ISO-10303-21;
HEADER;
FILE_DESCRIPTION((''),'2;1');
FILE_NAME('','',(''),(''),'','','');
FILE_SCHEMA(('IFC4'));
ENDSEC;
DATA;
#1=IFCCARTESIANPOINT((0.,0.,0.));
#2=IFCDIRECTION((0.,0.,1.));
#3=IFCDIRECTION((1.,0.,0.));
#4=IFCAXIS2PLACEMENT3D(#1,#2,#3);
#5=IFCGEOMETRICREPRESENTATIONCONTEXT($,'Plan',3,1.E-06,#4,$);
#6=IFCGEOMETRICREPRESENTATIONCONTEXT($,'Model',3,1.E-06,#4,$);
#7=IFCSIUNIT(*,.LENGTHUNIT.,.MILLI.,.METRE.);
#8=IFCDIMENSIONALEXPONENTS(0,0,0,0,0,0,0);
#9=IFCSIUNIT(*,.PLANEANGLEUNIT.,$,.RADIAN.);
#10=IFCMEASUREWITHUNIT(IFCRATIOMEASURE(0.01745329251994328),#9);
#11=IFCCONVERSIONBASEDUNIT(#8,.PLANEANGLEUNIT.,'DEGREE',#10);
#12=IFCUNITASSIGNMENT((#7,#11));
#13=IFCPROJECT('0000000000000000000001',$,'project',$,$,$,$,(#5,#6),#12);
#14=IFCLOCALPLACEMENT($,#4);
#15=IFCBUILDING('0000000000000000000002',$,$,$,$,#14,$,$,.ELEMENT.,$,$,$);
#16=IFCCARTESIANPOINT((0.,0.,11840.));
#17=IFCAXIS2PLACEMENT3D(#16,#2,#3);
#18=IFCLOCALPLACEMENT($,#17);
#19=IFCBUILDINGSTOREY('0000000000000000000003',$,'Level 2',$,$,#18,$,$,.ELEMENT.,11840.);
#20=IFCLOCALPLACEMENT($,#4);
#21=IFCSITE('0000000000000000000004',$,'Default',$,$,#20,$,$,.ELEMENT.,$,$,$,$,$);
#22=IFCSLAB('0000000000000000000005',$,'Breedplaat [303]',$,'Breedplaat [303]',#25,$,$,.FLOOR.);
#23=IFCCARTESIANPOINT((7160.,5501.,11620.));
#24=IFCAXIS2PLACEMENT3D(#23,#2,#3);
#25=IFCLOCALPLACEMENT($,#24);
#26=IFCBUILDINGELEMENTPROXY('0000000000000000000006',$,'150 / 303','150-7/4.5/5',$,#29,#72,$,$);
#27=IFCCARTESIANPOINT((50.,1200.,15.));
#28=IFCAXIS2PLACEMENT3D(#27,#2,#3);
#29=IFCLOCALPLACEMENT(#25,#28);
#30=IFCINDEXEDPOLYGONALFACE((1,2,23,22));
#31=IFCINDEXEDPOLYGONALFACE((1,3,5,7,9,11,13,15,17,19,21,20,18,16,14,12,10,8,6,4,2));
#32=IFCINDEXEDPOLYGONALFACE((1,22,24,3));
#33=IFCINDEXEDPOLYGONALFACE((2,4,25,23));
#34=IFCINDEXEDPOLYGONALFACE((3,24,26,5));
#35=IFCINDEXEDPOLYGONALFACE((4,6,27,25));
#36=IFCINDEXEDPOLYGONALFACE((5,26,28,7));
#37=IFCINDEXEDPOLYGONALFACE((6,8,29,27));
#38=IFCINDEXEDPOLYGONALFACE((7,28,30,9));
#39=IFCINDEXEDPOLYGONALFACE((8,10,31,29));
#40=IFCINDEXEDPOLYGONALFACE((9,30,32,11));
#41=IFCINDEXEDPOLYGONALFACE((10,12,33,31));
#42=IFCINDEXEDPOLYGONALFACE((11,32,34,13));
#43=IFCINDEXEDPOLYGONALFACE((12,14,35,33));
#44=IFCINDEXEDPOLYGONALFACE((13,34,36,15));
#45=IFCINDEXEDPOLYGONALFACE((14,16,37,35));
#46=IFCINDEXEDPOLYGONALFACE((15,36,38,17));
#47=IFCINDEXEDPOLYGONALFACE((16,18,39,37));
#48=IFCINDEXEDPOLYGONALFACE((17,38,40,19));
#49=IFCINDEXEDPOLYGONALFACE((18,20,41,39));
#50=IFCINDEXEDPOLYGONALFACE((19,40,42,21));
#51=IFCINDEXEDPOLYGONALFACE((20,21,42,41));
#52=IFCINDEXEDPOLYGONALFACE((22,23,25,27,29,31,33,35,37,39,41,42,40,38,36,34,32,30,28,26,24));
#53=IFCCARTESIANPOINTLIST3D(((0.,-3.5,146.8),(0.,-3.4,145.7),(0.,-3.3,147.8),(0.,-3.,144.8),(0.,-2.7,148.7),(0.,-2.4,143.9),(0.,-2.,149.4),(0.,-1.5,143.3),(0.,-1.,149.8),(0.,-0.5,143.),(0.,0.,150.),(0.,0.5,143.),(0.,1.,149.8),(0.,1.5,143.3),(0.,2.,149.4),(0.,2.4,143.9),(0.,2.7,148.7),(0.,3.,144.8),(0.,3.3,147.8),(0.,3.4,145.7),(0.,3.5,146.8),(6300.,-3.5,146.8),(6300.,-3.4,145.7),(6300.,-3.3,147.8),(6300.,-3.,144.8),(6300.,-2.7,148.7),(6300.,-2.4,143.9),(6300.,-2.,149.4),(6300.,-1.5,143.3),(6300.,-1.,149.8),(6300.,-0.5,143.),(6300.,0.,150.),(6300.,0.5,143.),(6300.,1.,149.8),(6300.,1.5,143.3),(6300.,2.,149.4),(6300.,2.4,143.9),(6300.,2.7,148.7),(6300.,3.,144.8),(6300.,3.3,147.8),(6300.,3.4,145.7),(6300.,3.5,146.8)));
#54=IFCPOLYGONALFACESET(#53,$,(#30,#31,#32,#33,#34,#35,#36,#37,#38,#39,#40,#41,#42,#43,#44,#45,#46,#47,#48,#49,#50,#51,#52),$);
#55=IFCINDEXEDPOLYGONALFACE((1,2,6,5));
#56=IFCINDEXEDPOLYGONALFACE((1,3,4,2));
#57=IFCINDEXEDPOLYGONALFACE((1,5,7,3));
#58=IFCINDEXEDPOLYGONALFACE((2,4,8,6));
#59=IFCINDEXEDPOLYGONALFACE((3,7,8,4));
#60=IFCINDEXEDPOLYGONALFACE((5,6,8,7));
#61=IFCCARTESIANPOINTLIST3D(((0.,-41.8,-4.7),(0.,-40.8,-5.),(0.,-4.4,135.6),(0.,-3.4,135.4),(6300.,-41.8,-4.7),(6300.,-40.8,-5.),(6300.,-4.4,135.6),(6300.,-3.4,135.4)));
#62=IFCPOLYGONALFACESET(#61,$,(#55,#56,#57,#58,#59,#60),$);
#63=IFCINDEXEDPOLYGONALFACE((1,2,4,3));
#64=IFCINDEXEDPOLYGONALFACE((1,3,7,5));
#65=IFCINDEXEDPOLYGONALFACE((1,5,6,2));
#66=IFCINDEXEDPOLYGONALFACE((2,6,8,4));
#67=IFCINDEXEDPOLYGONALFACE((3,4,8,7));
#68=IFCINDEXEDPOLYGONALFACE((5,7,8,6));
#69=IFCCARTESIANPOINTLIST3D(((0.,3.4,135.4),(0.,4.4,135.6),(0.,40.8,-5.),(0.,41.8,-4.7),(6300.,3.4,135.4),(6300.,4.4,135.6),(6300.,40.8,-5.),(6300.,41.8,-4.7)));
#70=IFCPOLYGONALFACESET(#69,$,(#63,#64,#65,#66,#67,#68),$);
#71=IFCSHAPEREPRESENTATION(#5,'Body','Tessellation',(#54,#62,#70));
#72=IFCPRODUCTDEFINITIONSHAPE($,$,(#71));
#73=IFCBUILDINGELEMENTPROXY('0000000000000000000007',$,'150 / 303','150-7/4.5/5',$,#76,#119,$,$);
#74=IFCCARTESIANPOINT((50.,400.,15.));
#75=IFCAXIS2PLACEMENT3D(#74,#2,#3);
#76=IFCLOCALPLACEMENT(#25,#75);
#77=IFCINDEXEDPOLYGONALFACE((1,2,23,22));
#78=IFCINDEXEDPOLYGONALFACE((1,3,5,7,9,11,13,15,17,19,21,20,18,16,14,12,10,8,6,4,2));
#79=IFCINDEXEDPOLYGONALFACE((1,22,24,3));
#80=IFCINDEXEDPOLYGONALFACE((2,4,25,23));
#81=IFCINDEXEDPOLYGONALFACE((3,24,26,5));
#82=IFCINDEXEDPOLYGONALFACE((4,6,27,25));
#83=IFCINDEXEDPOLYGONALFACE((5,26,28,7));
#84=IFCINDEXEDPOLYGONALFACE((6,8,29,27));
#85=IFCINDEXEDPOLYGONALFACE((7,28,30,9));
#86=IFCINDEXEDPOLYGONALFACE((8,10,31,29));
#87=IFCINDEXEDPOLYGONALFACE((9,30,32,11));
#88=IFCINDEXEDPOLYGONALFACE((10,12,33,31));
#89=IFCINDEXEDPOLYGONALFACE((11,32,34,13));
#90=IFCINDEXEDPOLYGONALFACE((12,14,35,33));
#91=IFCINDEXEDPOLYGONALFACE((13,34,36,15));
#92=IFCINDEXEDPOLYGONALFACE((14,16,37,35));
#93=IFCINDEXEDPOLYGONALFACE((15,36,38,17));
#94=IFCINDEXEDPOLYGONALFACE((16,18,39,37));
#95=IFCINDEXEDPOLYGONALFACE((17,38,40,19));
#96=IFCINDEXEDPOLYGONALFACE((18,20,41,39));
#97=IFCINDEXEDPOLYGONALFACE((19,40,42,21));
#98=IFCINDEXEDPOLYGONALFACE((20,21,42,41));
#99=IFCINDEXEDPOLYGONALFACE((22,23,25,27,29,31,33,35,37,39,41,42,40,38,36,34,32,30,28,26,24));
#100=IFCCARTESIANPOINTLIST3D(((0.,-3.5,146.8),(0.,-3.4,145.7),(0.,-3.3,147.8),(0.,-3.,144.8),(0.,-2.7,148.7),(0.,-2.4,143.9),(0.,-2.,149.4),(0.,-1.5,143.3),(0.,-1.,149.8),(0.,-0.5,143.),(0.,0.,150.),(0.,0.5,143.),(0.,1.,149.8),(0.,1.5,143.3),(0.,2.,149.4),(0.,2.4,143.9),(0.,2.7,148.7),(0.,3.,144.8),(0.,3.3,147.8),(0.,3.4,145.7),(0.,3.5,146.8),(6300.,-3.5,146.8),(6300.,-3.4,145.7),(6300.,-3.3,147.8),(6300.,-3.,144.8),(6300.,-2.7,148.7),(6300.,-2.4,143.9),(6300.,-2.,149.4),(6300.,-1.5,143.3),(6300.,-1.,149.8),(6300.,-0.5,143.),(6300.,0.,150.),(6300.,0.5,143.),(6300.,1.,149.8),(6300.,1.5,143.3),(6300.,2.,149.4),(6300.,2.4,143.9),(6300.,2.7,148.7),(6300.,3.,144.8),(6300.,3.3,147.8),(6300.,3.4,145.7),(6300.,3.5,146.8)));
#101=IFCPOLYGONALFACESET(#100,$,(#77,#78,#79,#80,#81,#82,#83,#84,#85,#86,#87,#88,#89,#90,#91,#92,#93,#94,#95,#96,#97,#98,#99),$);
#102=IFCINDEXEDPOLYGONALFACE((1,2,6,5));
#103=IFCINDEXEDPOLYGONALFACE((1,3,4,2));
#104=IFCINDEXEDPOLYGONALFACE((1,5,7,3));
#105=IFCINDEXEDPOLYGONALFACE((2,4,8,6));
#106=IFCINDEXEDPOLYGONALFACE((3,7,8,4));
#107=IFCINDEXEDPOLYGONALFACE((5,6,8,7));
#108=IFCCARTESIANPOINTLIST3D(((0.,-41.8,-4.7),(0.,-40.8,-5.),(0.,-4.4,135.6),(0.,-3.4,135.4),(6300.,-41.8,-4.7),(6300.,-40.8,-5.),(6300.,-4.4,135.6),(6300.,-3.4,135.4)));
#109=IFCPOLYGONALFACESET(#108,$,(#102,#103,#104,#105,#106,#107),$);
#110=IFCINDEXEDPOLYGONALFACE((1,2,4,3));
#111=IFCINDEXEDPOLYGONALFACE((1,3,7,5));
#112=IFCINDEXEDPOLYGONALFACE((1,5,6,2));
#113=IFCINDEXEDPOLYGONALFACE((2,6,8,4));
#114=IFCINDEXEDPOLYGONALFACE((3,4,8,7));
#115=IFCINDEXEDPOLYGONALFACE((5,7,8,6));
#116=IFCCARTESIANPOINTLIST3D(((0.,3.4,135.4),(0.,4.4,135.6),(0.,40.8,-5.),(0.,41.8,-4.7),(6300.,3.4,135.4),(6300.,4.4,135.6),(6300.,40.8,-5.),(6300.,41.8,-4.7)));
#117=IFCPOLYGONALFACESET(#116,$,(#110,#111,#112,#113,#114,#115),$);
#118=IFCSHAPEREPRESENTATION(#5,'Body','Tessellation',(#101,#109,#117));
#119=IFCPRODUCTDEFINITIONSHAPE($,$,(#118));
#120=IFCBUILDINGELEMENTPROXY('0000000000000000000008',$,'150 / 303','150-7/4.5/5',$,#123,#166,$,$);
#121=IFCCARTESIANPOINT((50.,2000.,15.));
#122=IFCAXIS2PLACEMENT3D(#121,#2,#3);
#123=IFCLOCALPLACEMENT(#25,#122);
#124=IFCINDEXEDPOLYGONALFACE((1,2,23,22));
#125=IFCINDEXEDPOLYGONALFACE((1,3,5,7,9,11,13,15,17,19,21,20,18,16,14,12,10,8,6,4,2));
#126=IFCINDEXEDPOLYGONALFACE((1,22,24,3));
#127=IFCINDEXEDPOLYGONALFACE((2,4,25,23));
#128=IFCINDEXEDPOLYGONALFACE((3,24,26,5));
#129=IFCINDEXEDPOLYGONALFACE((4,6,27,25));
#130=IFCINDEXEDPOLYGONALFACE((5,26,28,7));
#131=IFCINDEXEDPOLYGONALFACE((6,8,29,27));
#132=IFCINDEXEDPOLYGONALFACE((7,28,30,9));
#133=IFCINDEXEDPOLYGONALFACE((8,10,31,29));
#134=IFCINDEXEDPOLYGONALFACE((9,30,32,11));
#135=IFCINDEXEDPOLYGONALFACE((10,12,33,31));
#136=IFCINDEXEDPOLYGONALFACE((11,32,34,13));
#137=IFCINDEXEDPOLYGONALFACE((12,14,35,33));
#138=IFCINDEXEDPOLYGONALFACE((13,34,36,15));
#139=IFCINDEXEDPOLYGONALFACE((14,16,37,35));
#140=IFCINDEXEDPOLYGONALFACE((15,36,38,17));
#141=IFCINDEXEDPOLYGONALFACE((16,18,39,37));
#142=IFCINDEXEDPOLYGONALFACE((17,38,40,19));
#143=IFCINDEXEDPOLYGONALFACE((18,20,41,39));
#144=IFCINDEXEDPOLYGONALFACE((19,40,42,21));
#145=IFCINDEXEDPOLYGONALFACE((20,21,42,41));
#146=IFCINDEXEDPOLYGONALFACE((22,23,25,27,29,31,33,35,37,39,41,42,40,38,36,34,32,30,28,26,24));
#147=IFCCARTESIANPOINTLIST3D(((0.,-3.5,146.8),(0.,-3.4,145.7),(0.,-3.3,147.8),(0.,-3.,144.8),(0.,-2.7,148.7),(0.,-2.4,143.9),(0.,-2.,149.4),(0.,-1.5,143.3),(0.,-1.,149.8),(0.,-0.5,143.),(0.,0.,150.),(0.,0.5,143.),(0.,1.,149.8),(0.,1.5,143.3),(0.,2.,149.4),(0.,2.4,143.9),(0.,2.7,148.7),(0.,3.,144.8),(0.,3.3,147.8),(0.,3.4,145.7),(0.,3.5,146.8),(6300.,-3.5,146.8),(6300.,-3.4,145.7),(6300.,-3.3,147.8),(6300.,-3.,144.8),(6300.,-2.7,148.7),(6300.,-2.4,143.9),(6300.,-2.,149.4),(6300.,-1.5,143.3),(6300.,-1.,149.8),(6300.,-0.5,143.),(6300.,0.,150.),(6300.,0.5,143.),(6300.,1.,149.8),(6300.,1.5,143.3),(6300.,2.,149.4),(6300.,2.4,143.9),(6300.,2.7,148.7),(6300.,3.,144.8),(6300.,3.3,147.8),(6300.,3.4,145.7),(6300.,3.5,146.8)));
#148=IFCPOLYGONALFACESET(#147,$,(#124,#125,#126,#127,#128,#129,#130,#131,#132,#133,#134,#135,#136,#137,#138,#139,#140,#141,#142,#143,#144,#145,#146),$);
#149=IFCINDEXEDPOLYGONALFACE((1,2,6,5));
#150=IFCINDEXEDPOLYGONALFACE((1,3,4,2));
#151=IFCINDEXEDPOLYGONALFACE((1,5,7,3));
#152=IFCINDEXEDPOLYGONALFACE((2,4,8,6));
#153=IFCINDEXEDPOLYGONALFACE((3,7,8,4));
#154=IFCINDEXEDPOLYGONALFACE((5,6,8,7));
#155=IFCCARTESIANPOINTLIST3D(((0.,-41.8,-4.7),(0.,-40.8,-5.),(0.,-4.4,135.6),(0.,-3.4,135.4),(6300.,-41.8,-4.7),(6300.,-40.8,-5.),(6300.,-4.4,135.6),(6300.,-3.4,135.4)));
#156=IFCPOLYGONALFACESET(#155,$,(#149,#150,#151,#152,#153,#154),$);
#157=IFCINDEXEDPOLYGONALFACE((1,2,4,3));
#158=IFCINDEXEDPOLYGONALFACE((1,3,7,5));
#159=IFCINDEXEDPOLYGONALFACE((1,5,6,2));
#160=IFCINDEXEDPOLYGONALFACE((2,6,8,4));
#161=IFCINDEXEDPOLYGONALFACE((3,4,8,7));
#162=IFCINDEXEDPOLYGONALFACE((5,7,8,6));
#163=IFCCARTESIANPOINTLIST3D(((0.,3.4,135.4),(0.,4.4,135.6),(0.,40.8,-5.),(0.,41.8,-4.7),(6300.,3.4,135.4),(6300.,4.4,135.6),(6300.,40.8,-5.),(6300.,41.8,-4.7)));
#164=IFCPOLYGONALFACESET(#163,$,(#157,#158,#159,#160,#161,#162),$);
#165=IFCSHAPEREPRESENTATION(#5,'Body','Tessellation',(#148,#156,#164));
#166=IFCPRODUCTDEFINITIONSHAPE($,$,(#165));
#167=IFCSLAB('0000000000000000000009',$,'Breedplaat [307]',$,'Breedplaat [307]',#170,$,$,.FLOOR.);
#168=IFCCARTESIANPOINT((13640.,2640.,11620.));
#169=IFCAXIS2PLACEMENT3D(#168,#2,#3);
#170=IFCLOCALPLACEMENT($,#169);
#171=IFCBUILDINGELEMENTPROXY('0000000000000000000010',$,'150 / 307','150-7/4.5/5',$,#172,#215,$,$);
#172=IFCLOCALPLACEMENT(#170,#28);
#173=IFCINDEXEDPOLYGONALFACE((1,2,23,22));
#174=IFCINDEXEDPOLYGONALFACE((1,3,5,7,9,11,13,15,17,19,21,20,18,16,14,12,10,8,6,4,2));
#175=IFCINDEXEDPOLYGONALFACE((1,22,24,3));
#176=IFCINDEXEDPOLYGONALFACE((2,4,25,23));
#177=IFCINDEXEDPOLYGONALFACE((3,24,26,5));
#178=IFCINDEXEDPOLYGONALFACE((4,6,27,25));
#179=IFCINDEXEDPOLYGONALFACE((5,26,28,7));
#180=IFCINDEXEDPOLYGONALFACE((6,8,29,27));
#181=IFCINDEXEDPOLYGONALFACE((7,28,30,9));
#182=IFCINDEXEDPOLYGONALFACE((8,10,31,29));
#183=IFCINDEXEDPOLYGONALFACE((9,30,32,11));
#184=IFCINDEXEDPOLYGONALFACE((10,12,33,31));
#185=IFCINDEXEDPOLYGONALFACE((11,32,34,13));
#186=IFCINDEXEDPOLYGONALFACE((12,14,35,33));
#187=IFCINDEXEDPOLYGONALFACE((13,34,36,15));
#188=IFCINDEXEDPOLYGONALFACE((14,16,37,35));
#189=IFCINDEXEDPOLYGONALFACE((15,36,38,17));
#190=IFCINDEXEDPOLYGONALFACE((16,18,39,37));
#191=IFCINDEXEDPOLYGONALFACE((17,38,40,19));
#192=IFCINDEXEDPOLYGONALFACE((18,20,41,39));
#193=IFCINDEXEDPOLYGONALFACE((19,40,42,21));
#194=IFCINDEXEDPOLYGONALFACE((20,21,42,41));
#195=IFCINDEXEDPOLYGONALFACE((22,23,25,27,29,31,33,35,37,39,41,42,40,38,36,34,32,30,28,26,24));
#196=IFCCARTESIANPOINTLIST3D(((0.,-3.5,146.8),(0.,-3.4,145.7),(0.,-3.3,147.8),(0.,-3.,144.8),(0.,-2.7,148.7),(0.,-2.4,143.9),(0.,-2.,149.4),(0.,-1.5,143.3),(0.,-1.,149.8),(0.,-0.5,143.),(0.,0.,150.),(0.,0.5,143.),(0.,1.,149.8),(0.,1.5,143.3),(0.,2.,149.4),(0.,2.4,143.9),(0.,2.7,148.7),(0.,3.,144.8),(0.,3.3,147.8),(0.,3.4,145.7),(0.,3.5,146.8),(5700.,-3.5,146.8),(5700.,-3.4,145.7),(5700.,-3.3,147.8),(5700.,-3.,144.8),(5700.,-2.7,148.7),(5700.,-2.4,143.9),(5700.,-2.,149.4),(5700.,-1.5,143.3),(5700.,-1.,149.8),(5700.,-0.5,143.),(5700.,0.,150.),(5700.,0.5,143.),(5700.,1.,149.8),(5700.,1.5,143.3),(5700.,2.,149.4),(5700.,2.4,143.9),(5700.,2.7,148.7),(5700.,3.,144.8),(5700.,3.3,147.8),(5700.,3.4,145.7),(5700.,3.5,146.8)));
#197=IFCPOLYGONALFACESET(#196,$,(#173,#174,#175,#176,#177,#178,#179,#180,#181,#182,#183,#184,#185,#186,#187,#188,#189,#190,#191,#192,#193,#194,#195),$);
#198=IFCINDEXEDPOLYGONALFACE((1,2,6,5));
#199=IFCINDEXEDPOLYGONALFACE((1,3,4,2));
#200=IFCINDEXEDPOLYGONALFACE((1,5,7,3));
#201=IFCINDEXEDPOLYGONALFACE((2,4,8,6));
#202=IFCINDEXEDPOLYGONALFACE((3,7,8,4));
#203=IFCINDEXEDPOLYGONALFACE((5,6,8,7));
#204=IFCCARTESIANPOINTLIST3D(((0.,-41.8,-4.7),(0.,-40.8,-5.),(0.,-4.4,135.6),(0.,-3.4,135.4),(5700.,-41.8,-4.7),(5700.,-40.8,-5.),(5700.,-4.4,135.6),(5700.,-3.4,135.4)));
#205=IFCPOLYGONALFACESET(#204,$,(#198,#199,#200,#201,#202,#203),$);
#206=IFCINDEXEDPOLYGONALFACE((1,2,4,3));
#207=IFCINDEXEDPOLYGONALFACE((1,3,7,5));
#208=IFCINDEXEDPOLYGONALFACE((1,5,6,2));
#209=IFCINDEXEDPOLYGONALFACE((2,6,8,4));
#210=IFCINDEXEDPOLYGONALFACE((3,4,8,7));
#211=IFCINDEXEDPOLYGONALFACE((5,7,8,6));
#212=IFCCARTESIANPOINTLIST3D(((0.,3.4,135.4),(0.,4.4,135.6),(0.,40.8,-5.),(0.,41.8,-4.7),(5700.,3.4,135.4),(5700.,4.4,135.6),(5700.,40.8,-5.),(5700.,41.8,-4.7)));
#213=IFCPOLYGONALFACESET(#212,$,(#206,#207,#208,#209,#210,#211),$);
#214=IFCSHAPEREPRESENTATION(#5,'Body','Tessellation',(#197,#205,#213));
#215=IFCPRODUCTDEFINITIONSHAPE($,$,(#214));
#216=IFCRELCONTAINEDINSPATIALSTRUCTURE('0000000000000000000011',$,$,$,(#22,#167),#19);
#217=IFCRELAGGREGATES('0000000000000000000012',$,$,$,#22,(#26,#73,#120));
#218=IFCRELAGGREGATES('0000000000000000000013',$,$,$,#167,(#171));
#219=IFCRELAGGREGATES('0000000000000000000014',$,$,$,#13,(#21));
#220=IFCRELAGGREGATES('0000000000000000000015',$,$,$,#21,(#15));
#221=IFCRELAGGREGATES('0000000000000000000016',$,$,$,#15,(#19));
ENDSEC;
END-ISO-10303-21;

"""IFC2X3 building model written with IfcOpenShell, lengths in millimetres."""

from ifc_helpers import new_model, entity, si_unit, converted_unit, frame, origin_with_axes, origin_2d_with_axis, place, context, project, spatial, rectangle, circle, extrude, element, aggregate, save


model = new_model("IFC2X3")

# Units and contexts
plan_context = context("Plan", 3, precision=1e-06, world=origin_with_axes())
model_context = context("Model", 3, precision=1e-06, world=origin_with_axes())
ifc_project = project(units=[si_unit("LENGTHUNIT", "METRE", prefix="MILLI"), converted_unit("PLANEANGLEUNIT", "DEGREE", entity("IfcRatioMeasure", 0.01745329251994328), si_unit("PLANEANGLEUNIT", "RADIAN"), dimensions=[0, 0, 0, 0, 0, 0, 0])], contexts=[plan_context, model_context])

# Site, building, storey
site_placement = place(None, origin_with_axes())
site = spatial("IfcSite", under=ifc_project, at=site_placement, Name="Default", CompositionType="ELEMENT")
building_placement = place(None, origin_with_axes())
building = spatial("IfcBuilding", under=site, at=building_placement, CompositionType="ELEMENT")
storey_placement = place(None, frame((0.0, 0.0, 11840.0), z_axis=(0.0, 0.0, 1.0), x_axis=(1.0, 0.0, 0.0)))
storey = spatial("IfcBuildingStorey", under=building, at=storey_placement, Name="Level 2", CompositionType="ELEMENT", Elevation=11840.0)

# Slab, building element proxies
slab_1_placement = place(None, frame((7160.0, 5501.0, 11620.0), z_axis=(0.0, 0.0, 1.0), x_axis=(1.0, 0.0, 0.0)))
slab_1 = element("IfcSlab", 1, at=slab_1_placement, inside=storey, Name="Breedplaat [303]", ObjectType="Breedplaat [303]", PredefinedType="FLOOR")
proxy_1_placement = place(slab_1_placement, frame((50.0, 1200.0, 15.0), z_axis=(0.0, 0.0, 1.0), x_axis=(1.0, 0.0, 0.0)))
proxy_1 = element("IfcBuildingElementProxy", 2, at=proxy_1_placement, Name="150 / 303", Description="150-7/4.5/5", context=plan_context, shape_type="SweptSolid", body=[
    extrude(circle(Radius=3.5, at=origin_2d_with_axis()), frame((0.0, 0.0, 146.5), z_axis=(1.0, 0.0, 0.0), x_axis=(0.0, 0.0, 1.0)), (0.0, 0.0, 1.0), 6300.0),
    extrude(rectangle(XDim=145.2, YDim=1.0, at=origin_2d_with_axis()), frame((0.0, -22.6, 65.3), z_axis=(1.0, 0.0, 0.0), x_axis=(0.0, 0.257663, 0.966235)), (0.0, 0.0, 1.0), 6300.0),
    extrude(rectangle(XDim=145.2, YDim=1.0, at=origin_2d_with_axis()), frame((0.0, 22.6, 65.3), z_axis=(1.0, 0.0, 0.0), x_axis=(0.0, -0.257663, 0.966235)), (0.0, 0.0, 1.0), 6300.0),
])
proxy_2_placement = place(slab_1_placement, frame((50.0, 400.0, 15.0), z_axis=(0.0, 0.0, 1.0), x_axis=(1.0, 0.0, 0.0)))
proxy_2 = element("IfcBuildingElementProxy", 3, at=proxy_2_placement, Name="150 / 303", Description="150-7/4.5/5", context=plan_context, shape_type="SweptSolid", body=[
    extrude(circle(Radius=3.5, at=origin_2d_with_axis()), frame((0.0, 0.0, 146.5), z_axis=(1.0, 0.0, 0.0), x_axis=(0.0, 0.0, 1.0)), (0.0, 0.0, 1.0), 6300.0),
    extrude(rectangle(XDim=145.2, YDim=1.0, at=origin_2d_with_axis()), frame((0.0, -22.6, 65.3), z_axis=(1.0, 0.0, 0.0), x_axis=(0.0, 0.257663, 0.966235)), (0.0, 0.0, 1.0), 6300.0),
    extrude(rectangle(XDim=145.2, YDim=1.0, at=origin_2d_with_axis()), frame((0.0, 22.6, 65.3), z_axis=(1.0, 0.0, 0.0), x_axis=(0.0, -0.257663, 0.966235)), (0.0, 0.0, 1.0), 6300.0),
])
proxy_3_placement = place(slab_1_placement, frame((50.0, 2000.0, 15.0), z_axis=(0.0, 0.0, 1.0), x_axis=(1.0, 0.0, 0.0)))
proxy_3 = element("IfcBuildingElementProxy", 4, at=proxy_3_placement, Name="150 / 303", Description="150-7/4.5/5", context=plan_context, shape_type="SweptSolid", body=[
    extrude(circle(Radius=3.5, at=origin_2d_with_axis()), frame((0.0, 0.0, 146.5), z_axis=(1.0, 0.0, 0.0), x_axis=(0.0, 0.0, 1.0)), (0.0, 0.0, 1.0), 6300.0),
    extrude(rectangle(XDim=145.2, YDim=1.0, at=origin_2d_with_axis()), frame((0.0, -22.6, 65.3), z_axis=(1.0, 0.0, 0.0), x_axis=(0.0, 0.257663, 0.966235)), (0.0, 0.0, 1.0), 6300.0),
    extrude(rectangle(XDim=145.2, YDim=1.0, at=origin_2d_with_axis()), frame((0.0, 22.6, 65.3), z_axis=(1.0, 0.0, 0.0), x_axis=(0.0, -0.257663, 0.966235)), (0.0, 0.0, 1.0), 6300.0),
])
aggregate(slab_1, [proxy_1, proxy_2, proxy_3])

# Slab, building element proxy
slab_2_placement = place(None, frame((13640.0, 2640.0, 11620.0), z_axis=(0.0, 0.0, 1.0), x_axis=(1.0, 0.0, 0.0)))
slab_2 = element("IfcSlab", 5, at=slab_2_placement, inside=storey, Name="Breedplaat [307]", ObjectType="Breedplaat [307]", PredefinedType="FLOOR")
proxy_4_placement = place(slab_2_placement, frame((50.0, 1200.0, 15.0), z_axis=(0.0, 0.0, 1.0), x_axis=(1.0, 0.0, 0.0)))
proxy_4 = element("IfcBuildingElementProxy", 6, at=proxy_4_placement, Name="150 / 307", Description="150-7/4.5/5", context=plan_context, shape_type="SweptSolid", body=[
    extrude(circle(Radius=3.5, at=origin_2d_with_axis()), frame((0.0, 0.0, 146.5), z_axis=(1.0, 0.0, 0.0), x_axis=(0.0, 0.0, 1.0)), (0.0, 0.0, 1.0), 5700.0),
    extrude(rectangle(XDim=145.2, YDim=1.0, at=origin_2d_with_axis()), frame((0.0, -22.6, 65.3), z_axis=(1.0, 0.0, 0.0), x_axis=(0.0, 0.257663, 0.966235)), (0.0, 0.0, 1.0), 5700.0),
    extrude(rectangle(XDim=145.2, YDim=1.0, at=origin_2d_with_axis()), frame((0.0, 22.6, 65.3), z_axis=(1.0, 0.0, 0.0), x_axis=(0.0, -0.257663, 0.966235)), (0.0, 0.0, 1.0), 5700.0),
])
aggregate(slab_2, [proxy_4])

save(model, "model.ifc")
